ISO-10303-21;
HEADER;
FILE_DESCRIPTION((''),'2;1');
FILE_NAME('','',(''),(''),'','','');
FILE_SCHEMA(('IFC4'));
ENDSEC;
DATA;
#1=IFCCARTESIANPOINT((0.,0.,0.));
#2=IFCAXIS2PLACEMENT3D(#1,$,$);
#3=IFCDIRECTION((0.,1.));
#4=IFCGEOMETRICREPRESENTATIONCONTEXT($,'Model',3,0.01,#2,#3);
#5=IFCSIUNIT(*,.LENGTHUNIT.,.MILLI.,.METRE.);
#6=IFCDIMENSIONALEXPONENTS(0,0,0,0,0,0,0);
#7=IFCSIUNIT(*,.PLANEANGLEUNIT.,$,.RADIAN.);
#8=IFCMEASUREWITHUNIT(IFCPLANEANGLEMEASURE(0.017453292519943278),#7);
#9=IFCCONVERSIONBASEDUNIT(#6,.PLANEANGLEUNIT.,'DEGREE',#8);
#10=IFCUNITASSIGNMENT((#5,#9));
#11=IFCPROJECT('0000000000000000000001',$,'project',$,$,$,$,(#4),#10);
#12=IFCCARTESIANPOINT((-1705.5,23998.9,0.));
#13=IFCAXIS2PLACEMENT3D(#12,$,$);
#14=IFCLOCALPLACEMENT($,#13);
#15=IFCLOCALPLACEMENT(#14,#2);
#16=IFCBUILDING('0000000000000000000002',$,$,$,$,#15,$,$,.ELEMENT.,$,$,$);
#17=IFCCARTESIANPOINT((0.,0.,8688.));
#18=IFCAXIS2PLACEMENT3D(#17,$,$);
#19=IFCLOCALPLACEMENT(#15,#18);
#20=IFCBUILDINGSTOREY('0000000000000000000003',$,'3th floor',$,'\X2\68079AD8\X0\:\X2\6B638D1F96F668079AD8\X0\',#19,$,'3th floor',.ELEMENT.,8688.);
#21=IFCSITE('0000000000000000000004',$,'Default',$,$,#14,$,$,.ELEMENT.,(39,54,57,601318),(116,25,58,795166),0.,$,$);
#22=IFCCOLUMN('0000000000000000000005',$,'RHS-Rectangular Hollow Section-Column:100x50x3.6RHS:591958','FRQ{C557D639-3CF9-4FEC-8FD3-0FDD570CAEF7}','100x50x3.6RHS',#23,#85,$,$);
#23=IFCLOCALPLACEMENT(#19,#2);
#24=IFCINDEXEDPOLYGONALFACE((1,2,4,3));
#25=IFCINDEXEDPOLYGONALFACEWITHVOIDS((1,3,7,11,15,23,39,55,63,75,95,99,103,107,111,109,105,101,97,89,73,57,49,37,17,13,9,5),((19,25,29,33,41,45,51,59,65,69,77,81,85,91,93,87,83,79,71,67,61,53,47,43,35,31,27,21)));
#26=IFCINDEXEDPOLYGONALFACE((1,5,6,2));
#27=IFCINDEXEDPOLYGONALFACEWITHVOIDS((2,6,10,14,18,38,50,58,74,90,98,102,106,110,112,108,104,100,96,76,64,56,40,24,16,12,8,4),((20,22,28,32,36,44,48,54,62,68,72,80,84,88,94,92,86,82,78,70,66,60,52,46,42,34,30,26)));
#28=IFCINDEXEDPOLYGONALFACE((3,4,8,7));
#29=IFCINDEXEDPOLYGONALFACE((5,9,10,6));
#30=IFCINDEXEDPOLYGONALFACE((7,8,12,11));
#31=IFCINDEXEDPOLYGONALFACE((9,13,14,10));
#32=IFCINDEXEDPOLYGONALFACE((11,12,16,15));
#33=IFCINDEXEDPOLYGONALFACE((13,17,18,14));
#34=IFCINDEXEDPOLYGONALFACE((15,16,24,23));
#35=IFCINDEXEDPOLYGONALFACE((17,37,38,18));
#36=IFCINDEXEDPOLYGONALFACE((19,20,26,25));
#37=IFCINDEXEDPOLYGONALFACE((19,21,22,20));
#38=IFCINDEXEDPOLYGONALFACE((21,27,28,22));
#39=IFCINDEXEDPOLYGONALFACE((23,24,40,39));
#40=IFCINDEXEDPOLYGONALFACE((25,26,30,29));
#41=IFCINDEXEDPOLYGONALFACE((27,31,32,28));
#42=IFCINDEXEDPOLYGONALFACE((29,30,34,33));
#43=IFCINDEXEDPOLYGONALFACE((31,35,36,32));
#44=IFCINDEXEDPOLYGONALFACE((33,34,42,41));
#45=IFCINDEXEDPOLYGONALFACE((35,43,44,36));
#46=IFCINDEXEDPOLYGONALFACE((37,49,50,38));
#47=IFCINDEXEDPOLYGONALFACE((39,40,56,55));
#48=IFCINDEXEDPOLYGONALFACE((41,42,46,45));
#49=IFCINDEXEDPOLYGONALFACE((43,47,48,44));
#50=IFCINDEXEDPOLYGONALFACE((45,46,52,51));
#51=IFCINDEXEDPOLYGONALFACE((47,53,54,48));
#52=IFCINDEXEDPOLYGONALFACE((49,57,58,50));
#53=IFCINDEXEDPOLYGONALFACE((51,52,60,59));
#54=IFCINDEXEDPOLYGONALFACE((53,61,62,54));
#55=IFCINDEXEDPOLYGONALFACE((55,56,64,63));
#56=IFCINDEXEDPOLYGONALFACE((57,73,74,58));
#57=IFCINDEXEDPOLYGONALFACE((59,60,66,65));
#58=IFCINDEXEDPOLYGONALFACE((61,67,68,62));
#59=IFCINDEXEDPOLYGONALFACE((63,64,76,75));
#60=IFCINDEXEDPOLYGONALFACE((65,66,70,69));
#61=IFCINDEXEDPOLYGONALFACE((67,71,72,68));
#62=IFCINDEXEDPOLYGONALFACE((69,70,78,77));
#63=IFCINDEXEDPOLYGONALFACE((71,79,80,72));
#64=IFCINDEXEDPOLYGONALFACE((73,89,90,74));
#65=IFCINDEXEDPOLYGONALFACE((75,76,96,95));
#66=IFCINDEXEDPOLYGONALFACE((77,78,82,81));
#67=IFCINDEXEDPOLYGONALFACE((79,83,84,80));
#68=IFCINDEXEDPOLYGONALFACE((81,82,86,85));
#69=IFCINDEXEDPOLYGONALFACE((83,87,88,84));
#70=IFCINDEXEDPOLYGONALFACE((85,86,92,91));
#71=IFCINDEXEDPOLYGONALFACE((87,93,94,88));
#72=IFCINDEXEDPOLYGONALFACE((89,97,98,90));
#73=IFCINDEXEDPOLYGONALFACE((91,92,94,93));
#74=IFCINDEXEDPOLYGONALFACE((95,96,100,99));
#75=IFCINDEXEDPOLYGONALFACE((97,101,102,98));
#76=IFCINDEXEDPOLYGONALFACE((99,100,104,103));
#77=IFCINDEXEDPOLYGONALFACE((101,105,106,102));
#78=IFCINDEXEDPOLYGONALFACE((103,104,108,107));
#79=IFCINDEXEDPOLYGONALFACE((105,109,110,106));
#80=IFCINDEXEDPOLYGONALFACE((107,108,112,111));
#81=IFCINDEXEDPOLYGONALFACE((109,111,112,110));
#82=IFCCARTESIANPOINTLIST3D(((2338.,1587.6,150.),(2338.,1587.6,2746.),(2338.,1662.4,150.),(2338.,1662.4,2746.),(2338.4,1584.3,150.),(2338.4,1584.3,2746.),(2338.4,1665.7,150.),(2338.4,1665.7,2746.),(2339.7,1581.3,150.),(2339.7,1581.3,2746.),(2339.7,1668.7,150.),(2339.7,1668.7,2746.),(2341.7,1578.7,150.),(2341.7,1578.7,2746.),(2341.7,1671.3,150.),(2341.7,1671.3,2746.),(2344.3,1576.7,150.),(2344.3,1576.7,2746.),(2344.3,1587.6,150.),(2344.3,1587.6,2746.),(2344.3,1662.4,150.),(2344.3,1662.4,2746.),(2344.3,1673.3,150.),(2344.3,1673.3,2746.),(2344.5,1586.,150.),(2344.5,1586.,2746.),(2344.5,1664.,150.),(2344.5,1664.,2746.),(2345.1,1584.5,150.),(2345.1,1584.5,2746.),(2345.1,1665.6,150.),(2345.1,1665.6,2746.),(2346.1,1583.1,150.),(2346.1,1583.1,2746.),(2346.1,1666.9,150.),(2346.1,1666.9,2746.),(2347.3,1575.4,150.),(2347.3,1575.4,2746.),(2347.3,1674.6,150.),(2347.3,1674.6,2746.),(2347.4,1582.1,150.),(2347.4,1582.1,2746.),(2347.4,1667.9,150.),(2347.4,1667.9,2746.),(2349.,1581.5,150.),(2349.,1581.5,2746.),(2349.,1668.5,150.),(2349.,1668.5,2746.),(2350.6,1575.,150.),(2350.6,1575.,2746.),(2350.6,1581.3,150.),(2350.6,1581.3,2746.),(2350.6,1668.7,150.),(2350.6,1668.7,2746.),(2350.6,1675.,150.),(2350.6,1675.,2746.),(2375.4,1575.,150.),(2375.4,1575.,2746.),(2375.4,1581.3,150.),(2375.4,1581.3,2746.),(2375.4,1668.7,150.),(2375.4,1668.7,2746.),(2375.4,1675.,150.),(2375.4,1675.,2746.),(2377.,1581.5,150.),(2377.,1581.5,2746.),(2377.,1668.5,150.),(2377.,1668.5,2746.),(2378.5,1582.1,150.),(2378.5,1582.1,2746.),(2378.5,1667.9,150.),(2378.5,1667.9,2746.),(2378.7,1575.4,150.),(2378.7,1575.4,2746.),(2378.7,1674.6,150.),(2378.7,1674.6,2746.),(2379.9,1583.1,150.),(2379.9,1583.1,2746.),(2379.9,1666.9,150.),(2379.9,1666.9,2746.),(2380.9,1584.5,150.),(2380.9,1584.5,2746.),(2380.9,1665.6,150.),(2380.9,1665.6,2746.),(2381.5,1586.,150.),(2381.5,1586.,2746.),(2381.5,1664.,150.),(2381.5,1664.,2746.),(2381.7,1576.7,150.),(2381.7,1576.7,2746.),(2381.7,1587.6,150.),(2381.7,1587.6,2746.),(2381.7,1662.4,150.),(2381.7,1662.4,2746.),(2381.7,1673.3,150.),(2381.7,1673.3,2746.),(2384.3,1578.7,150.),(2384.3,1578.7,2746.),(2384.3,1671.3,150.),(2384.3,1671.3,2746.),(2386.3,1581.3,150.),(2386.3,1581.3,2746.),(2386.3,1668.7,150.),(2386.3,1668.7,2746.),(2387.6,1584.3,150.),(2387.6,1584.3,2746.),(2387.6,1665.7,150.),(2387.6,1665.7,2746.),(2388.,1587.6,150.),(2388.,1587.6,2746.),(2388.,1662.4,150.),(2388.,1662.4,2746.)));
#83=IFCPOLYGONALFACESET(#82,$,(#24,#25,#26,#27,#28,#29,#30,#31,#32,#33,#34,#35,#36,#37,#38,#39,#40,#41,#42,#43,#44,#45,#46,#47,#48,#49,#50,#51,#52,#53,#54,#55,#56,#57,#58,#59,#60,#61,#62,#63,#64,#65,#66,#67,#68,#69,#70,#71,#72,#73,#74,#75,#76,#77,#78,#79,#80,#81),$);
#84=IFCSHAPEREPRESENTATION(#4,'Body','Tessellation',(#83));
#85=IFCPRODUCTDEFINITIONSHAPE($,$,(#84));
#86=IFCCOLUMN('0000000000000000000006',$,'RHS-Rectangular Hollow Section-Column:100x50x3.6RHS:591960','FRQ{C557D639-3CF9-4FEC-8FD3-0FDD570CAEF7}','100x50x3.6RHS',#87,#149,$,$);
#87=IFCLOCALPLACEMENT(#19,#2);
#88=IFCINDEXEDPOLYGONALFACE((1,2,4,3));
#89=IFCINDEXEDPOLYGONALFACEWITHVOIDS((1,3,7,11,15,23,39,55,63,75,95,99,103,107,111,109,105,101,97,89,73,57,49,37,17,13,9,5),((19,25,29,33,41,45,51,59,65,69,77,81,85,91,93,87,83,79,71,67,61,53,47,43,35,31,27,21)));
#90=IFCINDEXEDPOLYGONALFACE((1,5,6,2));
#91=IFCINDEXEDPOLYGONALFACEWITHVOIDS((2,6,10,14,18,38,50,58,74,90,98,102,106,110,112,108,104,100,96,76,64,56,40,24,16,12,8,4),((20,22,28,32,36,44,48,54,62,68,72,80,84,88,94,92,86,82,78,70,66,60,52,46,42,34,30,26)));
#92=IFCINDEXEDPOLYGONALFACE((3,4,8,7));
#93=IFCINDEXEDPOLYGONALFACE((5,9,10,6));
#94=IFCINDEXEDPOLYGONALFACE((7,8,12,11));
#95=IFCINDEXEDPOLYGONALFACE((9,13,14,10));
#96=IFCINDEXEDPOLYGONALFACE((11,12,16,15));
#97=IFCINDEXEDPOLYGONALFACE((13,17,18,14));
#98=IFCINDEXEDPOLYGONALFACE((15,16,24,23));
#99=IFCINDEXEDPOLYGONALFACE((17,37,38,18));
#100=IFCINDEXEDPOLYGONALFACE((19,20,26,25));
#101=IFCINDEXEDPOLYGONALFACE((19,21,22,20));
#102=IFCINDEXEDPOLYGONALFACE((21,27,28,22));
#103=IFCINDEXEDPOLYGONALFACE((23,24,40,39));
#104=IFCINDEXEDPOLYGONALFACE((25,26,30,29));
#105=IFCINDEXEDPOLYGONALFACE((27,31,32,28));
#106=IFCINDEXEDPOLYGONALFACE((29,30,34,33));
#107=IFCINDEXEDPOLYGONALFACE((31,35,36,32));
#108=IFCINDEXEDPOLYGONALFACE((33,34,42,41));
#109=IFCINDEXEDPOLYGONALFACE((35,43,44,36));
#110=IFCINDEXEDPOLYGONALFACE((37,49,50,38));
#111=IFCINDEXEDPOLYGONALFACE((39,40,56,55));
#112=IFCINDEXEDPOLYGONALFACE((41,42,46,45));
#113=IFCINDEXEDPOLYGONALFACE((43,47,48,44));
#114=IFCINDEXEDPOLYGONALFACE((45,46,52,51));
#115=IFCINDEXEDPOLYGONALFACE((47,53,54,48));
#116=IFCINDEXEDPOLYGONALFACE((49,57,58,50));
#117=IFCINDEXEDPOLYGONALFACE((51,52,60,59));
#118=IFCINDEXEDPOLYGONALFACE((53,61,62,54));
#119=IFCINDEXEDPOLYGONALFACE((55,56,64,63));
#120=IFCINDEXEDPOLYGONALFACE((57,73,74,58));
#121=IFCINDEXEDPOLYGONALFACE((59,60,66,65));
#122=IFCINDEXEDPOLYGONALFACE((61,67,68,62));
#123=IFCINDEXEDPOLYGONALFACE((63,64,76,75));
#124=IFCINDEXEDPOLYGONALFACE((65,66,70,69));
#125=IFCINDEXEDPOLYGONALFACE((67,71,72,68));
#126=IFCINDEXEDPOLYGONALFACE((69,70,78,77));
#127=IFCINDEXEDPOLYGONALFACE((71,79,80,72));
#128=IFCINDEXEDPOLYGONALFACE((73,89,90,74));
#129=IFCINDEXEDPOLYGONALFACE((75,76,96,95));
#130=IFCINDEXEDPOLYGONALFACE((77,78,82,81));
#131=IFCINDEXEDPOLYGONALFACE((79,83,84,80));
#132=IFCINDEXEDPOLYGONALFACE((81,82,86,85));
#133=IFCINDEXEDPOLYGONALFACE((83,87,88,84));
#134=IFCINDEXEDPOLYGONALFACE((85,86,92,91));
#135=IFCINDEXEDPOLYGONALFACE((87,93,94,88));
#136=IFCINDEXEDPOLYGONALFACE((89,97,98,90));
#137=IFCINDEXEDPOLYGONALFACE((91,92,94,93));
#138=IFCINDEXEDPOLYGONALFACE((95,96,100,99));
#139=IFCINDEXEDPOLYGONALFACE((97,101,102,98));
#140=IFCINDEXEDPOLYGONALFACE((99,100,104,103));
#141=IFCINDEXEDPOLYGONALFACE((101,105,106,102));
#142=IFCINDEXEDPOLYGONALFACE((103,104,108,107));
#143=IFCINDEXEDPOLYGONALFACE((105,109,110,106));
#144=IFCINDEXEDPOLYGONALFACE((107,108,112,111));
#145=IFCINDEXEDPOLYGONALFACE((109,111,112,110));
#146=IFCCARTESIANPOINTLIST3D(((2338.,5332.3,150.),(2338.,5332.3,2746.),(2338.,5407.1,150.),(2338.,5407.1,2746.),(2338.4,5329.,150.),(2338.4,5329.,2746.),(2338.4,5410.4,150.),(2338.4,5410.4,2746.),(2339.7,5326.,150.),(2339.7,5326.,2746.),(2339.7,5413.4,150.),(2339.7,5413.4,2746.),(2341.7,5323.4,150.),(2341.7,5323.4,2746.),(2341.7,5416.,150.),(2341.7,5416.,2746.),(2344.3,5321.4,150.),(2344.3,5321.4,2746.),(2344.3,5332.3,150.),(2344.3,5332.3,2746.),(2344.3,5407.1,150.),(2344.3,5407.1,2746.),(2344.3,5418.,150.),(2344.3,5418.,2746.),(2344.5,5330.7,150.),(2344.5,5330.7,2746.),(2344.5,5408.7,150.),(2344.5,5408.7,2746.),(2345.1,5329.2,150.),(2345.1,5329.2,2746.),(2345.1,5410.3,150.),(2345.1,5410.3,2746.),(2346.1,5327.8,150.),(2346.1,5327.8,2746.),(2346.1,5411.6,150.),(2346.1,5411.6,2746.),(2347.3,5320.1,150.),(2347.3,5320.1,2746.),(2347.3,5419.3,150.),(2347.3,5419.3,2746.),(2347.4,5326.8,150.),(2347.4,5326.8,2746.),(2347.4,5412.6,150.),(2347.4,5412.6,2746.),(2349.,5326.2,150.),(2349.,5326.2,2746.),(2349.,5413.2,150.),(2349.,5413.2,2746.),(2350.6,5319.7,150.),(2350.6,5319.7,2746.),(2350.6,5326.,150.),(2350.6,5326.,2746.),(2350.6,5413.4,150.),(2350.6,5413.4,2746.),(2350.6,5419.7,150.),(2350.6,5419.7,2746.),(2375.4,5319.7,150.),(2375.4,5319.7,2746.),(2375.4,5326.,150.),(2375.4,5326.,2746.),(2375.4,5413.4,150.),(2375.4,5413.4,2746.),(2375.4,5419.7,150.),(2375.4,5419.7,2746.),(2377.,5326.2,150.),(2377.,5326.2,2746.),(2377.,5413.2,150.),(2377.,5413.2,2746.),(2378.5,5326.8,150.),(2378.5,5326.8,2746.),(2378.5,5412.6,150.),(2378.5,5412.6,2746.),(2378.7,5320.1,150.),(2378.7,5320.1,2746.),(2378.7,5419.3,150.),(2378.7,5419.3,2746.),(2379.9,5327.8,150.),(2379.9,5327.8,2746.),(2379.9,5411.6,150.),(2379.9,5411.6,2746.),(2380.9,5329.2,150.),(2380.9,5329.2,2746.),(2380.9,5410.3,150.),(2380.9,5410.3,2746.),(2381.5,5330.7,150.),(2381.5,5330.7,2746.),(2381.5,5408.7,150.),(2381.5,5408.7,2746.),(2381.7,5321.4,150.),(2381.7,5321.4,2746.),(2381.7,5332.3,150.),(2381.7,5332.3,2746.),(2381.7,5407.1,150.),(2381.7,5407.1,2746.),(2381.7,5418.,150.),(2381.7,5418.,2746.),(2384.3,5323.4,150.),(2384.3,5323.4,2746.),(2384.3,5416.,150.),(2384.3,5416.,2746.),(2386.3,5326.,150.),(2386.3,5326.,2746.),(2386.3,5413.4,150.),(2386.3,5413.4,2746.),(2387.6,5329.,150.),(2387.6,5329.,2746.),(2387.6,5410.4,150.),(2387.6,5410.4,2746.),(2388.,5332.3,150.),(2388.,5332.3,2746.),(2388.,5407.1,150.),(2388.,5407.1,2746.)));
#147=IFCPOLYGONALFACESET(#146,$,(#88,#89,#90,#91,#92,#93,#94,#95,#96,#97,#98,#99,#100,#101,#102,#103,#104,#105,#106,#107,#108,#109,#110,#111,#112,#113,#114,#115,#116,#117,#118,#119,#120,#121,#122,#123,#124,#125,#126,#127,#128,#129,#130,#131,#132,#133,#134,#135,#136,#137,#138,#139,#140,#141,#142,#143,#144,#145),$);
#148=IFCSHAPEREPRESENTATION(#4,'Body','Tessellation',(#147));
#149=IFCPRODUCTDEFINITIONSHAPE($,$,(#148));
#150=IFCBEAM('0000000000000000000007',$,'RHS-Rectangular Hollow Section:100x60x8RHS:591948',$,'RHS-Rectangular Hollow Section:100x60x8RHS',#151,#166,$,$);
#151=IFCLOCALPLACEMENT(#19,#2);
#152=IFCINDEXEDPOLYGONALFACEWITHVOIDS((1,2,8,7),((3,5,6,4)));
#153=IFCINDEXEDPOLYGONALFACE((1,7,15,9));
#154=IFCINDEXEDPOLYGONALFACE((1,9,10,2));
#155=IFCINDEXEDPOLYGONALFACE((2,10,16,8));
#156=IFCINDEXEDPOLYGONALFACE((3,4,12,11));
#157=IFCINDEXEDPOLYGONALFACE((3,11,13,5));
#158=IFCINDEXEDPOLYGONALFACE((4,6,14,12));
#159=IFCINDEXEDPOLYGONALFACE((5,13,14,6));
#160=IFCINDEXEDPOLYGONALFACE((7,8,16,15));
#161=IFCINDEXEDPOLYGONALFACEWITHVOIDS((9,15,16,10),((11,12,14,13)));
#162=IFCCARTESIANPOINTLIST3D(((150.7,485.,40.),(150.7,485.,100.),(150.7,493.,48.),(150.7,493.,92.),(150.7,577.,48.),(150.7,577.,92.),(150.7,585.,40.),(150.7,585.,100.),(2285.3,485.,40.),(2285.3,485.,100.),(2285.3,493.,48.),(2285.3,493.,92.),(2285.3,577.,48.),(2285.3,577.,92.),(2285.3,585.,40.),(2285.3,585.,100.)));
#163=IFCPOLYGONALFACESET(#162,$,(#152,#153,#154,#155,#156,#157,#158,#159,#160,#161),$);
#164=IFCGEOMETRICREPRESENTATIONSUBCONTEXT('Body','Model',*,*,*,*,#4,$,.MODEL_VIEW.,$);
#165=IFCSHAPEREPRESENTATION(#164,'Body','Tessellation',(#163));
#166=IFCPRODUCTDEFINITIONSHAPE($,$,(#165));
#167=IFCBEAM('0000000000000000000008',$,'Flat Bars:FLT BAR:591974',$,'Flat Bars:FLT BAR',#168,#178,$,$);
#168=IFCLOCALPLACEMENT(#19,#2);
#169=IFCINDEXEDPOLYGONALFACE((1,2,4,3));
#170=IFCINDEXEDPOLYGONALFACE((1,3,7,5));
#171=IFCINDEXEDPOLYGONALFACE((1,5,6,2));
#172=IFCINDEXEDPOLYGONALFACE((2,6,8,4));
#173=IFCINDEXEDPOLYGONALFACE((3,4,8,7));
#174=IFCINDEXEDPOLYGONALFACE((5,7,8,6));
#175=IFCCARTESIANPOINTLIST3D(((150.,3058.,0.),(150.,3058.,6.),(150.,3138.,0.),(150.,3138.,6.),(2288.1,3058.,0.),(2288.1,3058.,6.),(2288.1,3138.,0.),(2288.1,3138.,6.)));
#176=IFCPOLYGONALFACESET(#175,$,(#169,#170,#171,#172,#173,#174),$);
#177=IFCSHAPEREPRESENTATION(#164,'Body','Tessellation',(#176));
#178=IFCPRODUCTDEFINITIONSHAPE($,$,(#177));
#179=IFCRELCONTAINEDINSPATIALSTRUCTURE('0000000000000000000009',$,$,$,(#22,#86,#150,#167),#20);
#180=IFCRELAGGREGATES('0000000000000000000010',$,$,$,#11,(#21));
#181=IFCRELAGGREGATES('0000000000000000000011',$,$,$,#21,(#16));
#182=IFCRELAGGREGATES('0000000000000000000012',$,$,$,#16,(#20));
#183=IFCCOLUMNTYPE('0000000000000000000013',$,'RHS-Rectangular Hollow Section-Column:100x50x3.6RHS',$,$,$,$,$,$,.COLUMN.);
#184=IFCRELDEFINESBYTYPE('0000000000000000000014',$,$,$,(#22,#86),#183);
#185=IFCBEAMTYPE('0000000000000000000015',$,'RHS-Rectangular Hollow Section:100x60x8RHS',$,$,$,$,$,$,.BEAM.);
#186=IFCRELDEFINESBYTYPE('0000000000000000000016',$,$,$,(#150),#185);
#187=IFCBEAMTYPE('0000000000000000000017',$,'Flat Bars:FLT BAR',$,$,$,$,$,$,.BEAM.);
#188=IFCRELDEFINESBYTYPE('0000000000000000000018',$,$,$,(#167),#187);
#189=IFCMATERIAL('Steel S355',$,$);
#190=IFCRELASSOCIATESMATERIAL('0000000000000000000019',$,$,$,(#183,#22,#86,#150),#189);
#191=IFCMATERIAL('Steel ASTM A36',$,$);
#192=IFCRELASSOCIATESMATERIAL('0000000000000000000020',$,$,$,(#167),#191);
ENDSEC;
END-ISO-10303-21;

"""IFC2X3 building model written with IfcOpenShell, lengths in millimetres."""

from ifc_helpers import new_model, entity, si_unit, converted_unit, direction, frame, frame_2d, origin, origin_2d, place, context, subcontext, project, spatial, rectangle, hollow_rectangle, extrude, boolean, clip, halfspace, material, type_object, element, save


model = new_model("IFC2X3")

# Units and contexts
model_context = context("Model", 3, precision=0.01, world=origin(), true_north=direction((0.0, 1.0)))
body_context = subcontext(model_context, "Body", "Model", "MODEL_VIEW")
ifc_project = project(units=[si_unit("LENGTHUNIT", "METRE", prefix="MILLI"), converted_unit("PLANEANGLEUNIT", "DEGREE", entity("IfcPlaneAngleMeasure", 0.017453292519943278), si_unit("PLANEANGLEUNIT", "RADIAN"), dimensions=[0, 0, 0, 0, 0, 0, 0])], contexts=[model_context])

# Site, building, storey
site_placement = place(None, frame((-1705.5, 23998.9, 0.0)))
site = spatial("IfcSite", under=ifc_project, at=site_placement, Name="Default", CompositionType="ELEMENT", RefLatitude=(39, 54, 57, 601318), RefLongitude=(116, 25, 58, 795166), RefElevation=0.0)
building_placement = place(site_placement, origin())
building = spatial("IfcBuilding", under=site, at=building_placement, CompositionType="ELEMENT")
storey_placement = place(building_placement, frame((0.0, 0.0, 8688.0)))
storey = spatial("IfcBuildingStorey", under=building, at=storey_placement, Name="3th floor", ObjectType="标高:正负零标高", LongName="3th floor", CompositionType="ELEMENT", Elevation=8688.0)

# Shared definitions
ifc_material_1 = material(Name="Steel S355")

# Columns
column_type_1 = type_object("IfcColumnType", Name="RHS-Rectangular Hollow Section-Column:100x50x3.6RHS", PredefinedType="COLUMN", material=ifc_material_1)
column_1_placement = place(storey_placement, frame((2363.0, 1625.0, 2746.0), z_axis=(0.0, 0.0, 1.0), x_axis=(-1.0, 0.0, 0.0)))
element("IfcColumn", 1, at=column_1_placement, inside=storey, type_object=column_type_1, material=ifc_material_1, Name="RHS-Rectangular Hollow Section-Column:100x50x3.6RHS:591958", Description="FRQ{C557D639-3CF9-4FEC-8FD3-0FDD570CAEF7}", ObjectType="100x50x3.6RHS", context=model_context, shape_type="Clipping", body=[
    clip(extrude(hollow_rectangle(XDim=50.0, YDim=100.0, WallThickness=6.3, InnerFilletRadius=6.3, OuterFilletRadius=12.6, at=origin_2d()), origin(), (0.0, 0.0, -1.0), 2651.9), halfspace(frame((2363.0, 1625.0, -2596.0), z_axis=(0.0, 0.0, 1.0), x_axis=(-1.0, 0.0, 0.0)), True)),
])
column_2_placement = place(storey_placement, frame((2363.0, 5369.7, 2746.0), z_axis=(0.0, 0.0, 1.0), x_axis=(-1.0, 0.0, 0.0)))
element("IfcColumn", 2, at=column_2_placement, inside=storey, type_object=column_type_1, material=ifc_material_1, Name="RHS-Rectangular Hollow Section-Column:100x50x3.6RHS:591960", Description="FRQ{C557D639-3CF9-4FEC-8FD3-0FDD570CAEF7}", ObjectType="100x50x3.6RHS", context=model_context, shape_type="Clipping", body=[
    clip(extrude(hollow_rectangle(XDim=50.0, YDim=100.0, WallThickness=6.3, InnerFilletRadius=6.3, OuterFilletRadius=12.6, at=origin_2d()), origin(), (0.0, 0.0, -1.0), 2651.9), halfspace(frame((2363.0, 5369.7, -2596.0), z_axis=(0.0, 0.0, 1.0), x_axis=(-1.0, 0.0, 0.0)), True)),
])

# Beams
beam_type_1 = type_object("IfcBeamType", Name="RHS-Rectangular Hollow Section:100x60x8RHS", PredefinedType="BEAM")
beam_1_placement = place(storey_placement, frame((150.7, 585.0, 70.0)))
element("IfcBeam", 3, at=beam_1_placement, inside=storey, type_object=beam_type_1, material=ifc_material_1, Name="RHS-Rectangular Hollow Section:100x60x8RHS:591948", ObjectType="RHS-Rectangular Hollow Section:100x60x8RHS", context=body_context, shape_type="SweptSolid", body=[
    boolean("DIFFERENCE", extrude(rectangle(XDim=60.0, YDim=100.0, at=frame_2d((0.0, 0.0), x_axis=(1.0, 0.0))), frame((0.0, -50.0, 0.0), z_axis=(1.0, 0.0, 0.0), x_axis=(0.0, 0.0, -1.0)), (0.0, 0.0, 1.0), 2134.6), extrude(rectangle(XDim=44.0, YDim=84.0, at=frame_2d((0.0, 0.0), x_axis=(0.0, 1.0))), frame((2134.6, -50.0, 0.0), z_axis=(-1.0, 0.0, 0.0), x_axis=(0.0, 1.0, 0.0)), (0.0, 0.0, 1.0), 2134.6)),
])
ifc_material_2 = material(Name="Steel ASTM A36")
beam_type_2 = type_object("IfcBeamType", Name="Flat Bars:FLT BAR", PredefinedType="BEAM")
beam_2_placement = place(storey_placement, frame((150.0, 3098.0, 6.0)))
element("IfcBeam", 4, at=beam_2_placement, inside=storey, type_object=beam_type_2, material=ifc_material_2, Name="Flat Bars:FLT BAR:591974", ObjectType="Flat Bars:FLT BAR", context=body_context, shape_type="SweptSolid", body=[
    extrude(rectangle(XDim=6.0, YDim=80.0, at=frame_2d((0.0, 0.0), x_axis=(1.0, 0.0))), frame((0.0, 0.0, -3.0), z_axis=(1.0, 0.0, 0.0), x_axis=(0.0, 0.0, -1.0)), (0.0, 0.0, 1.0), 2138.1),
])

save(model, "model.ifc")
